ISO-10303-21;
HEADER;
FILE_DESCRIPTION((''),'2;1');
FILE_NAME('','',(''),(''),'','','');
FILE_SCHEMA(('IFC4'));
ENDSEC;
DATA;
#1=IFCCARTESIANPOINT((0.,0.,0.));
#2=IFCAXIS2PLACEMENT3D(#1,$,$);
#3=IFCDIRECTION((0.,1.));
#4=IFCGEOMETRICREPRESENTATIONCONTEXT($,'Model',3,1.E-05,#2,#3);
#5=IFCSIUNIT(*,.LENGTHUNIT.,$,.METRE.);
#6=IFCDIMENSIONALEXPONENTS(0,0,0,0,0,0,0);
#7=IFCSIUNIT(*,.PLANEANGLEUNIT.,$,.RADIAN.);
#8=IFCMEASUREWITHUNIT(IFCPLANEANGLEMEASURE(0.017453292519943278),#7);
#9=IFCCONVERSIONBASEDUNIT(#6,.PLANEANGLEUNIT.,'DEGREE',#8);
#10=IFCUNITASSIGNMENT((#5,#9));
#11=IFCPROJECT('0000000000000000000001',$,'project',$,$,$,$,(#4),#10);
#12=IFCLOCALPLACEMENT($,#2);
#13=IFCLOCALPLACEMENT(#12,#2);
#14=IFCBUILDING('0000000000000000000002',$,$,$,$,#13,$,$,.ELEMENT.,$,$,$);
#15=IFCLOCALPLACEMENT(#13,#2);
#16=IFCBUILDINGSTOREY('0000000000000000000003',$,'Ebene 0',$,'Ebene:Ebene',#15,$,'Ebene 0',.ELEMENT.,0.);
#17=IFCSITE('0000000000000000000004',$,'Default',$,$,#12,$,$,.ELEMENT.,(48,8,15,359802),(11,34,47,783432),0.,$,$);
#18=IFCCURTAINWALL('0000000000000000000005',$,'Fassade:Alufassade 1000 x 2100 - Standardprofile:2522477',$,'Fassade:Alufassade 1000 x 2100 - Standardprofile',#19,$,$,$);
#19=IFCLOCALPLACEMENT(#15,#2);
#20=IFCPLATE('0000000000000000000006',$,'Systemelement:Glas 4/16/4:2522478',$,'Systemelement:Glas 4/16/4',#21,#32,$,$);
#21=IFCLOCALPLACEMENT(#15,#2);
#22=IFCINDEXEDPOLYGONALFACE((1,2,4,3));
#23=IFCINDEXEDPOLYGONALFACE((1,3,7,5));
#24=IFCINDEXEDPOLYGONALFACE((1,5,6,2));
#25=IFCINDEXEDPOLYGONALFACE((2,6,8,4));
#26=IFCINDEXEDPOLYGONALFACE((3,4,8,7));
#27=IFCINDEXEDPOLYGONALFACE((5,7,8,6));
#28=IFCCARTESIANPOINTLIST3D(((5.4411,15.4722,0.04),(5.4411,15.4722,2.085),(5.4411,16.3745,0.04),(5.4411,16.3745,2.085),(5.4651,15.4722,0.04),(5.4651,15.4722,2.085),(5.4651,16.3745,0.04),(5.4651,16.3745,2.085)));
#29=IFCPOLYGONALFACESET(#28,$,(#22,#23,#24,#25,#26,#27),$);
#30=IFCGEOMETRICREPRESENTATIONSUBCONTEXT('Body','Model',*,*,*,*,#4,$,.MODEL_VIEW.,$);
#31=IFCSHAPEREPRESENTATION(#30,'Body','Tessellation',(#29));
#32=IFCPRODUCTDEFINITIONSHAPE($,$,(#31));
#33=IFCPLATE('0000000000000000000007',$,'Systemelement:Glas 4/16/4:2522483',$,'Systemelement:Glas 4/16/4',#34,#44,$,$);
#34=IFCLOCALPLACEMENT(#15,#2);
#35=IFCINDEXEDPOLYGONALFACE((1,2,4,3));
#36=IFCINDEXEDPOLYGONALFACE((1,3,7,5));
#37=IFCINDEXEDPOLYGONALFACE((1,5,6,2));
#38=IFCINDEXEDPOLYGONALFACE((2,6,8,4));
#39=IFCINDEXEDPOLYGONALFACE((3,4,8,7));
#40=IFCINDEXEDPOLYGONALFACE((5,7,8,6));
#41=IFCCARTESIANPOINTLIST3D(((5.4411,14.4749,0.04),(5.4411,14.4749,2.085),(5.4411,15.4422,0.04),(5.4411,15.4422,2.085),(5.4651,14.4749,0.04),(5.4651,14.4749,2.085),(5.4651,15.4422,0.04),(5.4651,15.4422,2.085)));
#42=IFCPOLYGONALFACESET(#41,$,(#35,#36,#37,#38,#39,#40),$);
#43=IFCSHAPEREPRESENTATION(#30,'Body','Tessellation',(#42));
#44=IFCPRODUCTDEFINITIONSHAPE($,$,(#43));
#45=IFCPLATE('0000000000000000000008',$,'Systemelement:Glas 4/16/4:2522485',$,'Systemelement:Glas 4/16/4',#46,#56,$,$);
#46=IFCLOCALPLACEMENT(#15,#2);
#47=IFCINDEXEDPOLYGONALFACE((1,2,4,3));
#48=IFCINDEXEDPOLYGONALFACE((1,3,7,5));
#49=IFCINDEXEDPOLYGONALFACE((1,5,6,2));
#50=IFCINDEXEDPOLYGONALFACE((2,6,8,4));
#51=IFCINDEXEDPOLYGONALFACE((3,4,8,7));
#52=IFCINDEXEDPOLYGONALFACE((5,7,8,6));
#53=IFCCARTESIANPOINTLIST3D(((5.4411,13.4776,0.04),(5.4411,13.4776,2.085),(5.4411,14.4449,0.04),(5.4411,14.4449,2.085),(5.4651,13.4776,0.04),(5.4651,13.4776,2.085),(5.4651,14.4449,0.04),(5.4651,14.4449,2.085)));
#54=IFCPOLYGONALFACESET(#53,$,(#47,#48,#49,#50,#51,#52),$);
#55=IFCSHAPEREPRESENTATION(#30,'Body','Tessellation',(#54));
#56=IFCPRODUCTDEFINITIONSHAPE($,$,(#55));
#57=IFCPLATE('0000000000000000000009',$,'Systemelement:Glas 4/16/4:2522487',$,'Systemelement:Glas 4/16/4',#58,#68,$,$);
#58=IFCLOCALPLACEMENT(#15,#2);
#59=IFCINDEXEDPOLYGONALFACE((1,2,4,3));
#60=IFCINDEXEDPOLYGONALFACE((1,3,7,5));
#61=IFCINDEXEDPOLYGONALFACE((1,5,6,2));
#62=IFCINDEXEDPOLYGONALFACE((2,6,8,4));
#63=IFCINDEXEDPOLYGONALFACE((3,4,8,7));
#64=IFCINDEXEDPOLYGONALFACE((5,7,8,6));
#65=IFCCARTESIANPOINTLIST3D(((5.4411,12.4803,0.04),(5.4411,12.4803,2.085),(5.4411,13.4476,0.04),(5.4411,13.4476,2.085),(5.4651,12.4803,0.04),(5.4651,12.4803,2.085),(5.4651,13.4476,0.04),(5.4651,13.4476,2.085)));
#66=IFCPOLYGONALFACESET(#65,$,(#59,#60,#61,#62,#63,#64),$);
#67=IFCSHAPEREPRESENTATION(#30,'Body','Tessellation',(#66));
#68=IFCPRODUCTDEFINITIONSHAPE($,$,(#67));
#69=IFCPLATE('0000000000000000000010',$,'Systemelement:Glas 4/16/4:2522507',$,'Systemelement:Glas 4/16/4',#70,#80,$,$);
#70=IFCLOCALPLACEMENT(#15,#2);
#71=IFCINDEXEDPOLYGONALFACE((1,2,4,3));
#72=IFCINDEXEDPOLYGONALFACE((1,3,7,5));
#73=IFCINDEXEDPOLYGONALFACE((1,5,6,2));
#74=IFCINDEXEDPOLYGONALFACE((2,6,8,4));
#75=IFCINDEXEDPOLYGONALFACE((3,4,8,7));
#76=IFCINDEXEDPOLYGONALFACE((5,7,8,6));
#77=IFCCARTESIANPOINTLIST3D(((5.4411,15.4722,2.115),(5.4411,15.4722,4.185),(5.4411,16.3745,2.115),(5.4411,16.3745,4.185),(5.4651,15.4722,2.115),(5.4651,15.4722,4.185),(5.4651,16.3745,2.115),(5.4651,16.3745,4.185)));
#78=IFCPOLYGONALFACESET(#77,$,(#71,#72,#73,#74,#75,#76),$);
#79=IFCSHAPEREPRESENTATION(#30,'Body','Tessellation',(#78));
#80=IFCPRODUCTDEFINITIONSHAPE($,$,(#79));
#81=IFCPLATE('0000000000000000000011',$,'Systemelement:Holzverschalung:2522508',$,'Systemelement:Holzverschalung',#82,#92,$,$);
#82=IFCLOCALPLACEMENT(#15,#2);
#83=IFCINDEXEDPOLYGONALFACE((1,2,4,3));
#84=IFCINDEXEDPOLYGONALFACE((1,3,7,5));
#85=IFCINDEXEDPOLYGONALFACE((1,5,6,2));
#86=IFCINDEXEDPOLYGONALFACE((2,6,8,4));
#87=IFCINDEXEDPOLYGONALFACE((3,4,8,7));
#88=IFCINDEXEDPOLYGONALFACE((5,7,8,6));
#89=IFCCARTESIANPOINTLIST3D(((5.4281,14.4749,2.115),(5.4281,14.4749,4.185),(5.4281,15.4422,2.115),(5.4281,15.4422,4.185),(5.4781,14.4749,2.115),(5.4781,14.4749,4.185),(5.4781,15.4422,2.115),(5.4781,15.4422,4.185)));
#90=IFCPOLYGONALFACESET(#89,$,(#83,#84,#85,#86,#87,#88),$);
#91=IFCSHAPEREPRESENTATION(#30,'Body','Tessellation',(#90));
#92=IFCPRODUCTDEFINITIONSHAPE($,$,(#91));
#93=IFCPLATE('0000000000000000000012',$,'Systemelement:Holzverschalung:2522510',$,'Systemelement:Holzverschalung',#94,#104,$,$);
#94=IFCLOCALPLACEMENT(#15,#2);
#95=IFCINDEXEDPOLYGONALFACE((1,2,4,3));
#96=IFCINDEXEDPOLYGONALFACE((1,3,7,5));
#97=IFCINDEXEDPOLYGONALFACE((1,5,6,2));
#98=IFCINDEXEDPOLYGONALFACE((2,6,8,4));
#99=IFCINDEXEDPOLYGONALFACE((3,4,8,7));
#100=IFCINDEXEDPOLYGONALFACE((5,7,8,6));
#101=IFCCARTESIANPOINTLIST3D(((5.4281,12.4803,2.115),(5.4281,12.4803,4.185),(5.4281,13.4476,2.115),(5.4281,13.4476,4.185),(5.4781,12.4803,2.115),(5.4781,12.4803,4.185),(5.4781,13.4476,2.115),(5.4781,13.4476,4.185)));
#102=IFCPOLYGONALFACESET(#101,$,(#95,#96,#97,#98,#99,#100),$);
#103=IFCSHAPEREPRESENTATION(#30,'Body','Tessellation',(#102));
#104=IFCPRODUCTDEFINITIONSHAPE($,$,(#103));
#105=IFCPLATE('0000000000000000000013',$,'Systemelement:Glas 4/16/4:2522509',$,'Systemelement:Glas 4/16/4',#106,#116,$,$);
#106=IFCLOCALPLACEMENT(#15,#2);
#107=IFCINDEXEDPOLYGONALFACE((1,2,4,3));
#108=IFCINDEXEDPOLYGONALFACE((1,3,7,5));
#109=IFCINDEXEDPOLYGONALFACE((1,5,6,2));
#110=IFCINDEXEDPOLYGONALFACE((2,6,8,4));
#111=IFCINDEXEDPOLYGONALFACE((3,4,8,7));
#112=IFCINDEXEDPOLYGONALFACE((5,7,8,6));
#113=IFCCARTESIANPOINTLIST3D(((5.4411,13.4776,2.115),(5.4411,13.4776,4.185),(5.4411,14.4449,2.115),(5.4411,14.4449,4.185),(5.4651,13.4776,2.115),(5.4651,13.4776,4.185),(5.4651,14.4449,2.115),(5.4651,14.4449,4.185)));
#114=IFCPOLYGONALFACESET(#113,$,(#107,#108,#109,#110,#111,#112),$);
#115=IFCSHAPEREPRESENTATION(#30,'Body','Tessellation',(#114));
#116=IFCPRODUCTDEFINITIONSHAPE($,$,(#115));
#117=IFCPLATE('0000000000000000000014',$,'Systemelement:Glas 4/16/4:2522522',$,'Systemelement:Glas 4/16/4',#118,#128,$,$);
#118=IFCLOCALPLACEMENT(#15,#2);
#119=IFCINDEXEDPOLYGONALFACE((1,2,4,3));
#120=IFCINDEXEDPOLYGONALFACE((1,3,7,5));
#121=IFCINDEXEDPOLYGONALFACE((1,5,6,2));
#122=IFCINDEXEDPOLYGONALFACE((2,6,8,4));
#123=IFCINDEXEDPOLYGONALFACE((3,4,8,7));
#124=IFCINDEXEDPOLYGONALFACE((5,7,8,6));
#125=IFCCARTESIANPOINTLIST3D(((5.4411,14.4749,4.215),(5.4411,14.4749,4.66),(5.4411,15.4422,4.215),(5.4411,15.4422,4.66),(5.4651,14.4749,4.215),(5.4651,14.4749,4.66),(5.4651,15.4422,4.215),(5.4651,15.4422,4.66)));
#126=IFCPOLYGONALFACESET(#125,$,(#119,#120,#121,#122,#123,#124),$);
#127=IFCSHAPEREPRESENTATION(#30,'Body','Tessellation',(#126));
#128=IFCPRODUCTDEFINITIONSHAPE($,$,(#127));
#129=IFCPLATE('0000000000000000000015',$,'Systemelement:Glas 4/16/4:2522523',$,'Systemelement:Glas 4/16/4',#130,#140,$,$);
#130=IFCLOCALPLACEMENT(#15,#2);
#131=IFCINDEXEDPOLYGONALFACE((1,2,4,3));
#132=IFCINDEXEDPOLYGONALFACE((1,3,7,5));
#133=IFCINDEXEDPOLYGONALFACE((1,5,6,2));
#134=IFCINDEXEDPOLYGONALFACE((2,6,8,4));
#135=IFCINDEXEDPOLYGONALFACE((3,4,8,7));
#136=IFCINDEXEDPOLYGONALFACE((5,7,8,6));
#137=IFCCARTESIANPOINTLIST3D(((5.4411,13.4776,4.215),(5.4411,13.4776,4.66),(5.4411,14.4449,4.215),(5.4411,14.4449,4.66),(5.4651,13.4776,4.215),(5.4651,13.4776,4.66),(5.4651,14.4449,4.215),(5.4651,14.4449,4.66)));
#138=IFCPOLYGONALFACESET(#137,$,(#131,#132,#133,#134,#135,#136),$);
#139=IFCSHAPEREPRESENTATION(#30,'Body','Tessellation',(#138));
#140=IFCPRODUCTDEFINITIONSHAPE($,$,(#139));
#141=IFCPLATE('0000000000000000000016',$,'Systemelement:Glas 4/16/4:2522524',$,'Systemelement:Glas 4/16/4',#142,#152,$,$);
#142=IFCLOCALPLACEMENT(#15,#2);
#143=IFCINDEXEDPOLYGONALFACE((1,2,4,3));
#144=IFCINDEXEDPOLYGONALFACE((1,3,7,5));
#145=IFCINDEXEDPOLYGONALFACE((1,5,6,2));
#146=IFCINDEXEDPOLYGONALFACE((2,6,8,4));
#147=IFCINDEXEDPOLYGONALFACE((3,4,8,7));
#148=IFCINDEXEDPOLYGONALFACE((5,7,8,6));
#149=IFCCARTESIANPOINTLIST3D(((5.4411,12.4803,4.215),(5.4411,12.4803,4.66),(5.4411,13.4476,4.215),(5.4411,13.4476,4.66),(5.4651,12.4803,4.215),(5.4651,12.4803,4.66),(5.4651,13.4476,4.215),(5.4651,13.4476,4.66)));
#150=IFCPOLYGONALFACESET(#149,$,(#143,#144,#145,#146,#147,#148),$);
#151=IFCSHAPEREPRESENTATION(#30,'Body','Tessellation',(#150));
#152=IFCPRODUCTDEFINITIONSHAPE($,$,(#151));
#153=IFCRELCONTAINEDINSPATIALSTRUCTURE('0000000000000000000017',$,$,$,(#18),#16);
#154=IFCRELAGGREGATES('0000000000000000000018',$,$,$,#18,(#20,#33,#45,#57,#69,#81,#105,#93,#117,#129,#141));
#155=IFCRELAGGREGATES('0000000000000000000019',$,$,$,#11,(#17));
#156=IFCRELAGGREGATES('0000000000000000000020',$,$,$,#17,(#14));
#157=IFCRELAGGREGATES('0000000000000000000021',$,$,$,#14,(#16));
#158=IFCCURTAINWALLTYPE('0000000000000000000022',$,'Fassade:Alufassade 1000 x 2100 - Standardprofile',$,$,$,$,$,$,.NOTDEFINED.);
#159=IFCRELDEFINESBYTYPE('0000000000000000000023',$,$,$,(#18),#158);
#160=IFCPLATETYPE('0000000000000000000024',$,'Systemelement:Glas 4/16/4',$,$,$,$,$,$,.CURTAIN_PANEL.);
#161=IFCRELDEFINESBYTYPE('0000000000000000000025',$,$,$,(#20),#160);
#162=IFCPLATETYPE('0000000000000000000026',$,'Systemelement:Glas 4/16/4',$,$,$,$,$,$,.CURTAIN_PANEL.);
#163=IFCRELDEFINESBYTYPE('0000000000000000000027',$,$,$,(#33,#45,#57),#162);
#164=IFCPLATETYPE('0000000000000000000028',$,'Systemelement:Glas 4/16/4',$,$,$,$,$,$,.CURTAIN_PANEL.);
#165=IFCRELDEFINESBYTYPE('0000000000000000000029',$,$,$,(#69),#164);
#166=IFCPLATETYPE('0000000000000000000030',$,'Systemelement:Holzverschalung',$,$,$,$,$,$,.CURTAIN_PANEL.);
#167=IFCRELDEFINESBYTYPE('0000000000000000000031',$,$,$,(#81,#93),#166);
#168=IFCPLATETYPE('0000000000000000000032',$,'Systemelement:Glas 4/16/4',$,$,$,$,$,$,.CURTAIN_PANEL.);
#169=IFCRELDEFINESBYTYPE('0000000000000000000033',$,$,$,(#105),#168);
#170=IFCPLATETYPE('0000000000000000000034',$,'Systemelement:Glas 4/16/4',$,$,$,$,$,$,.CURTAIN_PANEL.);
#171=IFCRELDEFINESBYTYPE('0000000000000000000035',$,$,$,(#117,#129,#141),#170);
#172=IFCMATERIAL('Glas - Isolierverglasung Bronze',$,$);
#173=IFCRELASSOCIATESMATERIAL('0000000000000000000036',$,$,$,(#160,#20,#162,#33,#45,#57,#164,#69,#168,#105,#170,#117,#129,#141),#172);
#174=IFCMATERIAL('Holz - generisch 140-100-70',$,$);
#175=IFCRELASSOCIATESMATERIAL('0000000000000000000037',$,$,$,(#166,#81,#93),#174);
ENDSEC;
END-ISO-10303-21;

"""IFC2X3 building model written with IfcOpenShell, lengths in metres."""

from ifc_helpers import new_model, entity, si_unit, converted_unit, direction, frame, origin, origin_2d_with_axis, place, context, subcontext, project, spatial, rectangle, extrude, source, transform, mapped, material, type_object, type_shapes, element, aggregate, save


model = new_model("IFC2X3")

# Units and contexts
model_context = context("Model", 3, precision=1e-05, world=origin(), true_north=direction((0.0, 1.0)))
body_context = subcontext(model_context, "Body", "Model", "MODEL_VIEW")
ifc_project = project(units=[si_unit("LENGTHUNIT", "METRE"), converted_unit("PLANEANGLEUNIT", "DEGREE", entity("IfcPlaneAngleMeasure", 0.017453292519943278), si_unit("PLANEANGLEUNIT", "RADIAN"), dimensions=[0, 0, 0, 0, 0, 0, 0])], contexts=[model_context])

# Site, building, storey
site_placement = place(None, origin())
site = spatial("IfcSite", under=ifc_project, at=site_placement, Name="Default", CompositionType="ELEMENT", RefLatitude=(48, 8, 15, 359802), RefLongitude=(11, 34, 47, 783432), RefElevation=0.0)
building_placement = place(site_placement, origin())
building = spatial("IfcBuilding", under=site, at=building_placement, CompositionType="ELEMENT")
storey_placement = place(building_placement, origin())
storey = spatial("IfcBuildingStorey", under=building, at=storey_placement, Name="Ebene 0", ObjectType="Ebene:Ebene", LongName="Ebene 0", CompositionType="ELEMENT", Elevation=0.0)

# Curtain wall, plates
curtain_wall_type = type_object("IfcCurtainWallType", Name="Fassade:Alufassade 1000 x 2100 - Standardprofile", PredefinedType="NOTDEFINED")
curtain_wall_placement = place(storey_placement, origin())
curtain_wall = element("IfcCurtainWall", 1, at=curtain_wall_placement, inside=storey, type_object=curtain_wall_type, Name="Fassade:Alufassade 1000 x 2100 - Standardprofile:2522477", ObjectType="Fassade:Alufassade 1000 x 2100 - Standardprofile")
ifc_material_1 = material(Name="Glas - Isolierverglasung Bronze")
plate_type_1 = type_object("IfcPlateType", Name="Systemelement:Glas 4/16/4", PredefinedType="CURTAIN_PANEL", material=ifc_material_1)
shared_shape_1 = source(origin(), body_context, "Body", "SweptSolid", [
    extrude(rectangle(XDim=0.024, YDim=0.9023, at=origin_2d_with_axis()), frame((0.0, 0.0, 0.0), z_axis=(0.0, 0.0, 1.0), x_axis=(0.0, 1.0, 0.0)), (0.0, 0.0, 1.0), 2.045),
])
type_shapes(plate_type_1, [shared_shape_1])
plate_1_placement = place(curtain_wall_placement, frame((5.4531, 15.9233, 0.04), z_axis=(0.0, 0.0, 1.0), x_axis=(0.0, -1.0, 0.0)))
plate_1 = element("IfcPlate", 2, at=plate_1_placement, type_object=plate_type_1, material=ifc_material_1, Name="Systemelement:Glas 4/16/4:2522478", ObjectType="Systemelement:Glas 4/16/4", context=body_context, shape_type="MappedRepresentation", body=[
    mapped(shared_shape_1, transform((0.0, 0.0, 0.0), scale=1.0)),
])
plate_type_2 = type_object("IfcPlateType", Name="Systemelement:Glas 4/16/4", PredefinedType="CURTAIN_PANEL", material=ifc_material_1)
shared_shape_2 = source(origin(), body_context, "Body", "SweptSolid", [
    extrude(rectangle(XDim=0.024, YDim=0.9673, at=origin_2d_with_axis()), frame((0.0, 0.0, 0.0), z_axis=(0.0, 0.0, 1.0), x_axis=(0.0, 1.0, 0.0)), (0.0, 0.0, 1.0), 2.045),
])
type_shapes(plate_type_2, [shared_shape_2])
plate_2_placement = place(curtain_wall_placement, frame((5.4531, 14.9585, 0.04), z_axis=(0.0, 0.0, 1.0), x_axis=(0.0, -1.0, 0.0)))
plate_2 = element("IfcPlate", 3, at=plate_2_placement, type_object=plate_type_2, material=ifc_material_1, Name="Systemelement:Glas 4/16/4:2522483", ObjectType="Systemelement:Glas 4/16/4", context=body_context, shape_type="MappedRepresentation", body=[
    mapped(shared_shape_2, transform((0.0, 0.0, 0.0), scale=1.0)),
])
plate_3_placement = place(curtain_wall_placement, frame((5.4531, 13.9612, 0.04), z_axis=(0.0, 0.0, 1.0), x_axis=(0.0, -1.0, 0.0)))
plate_3 = element("IfcPlate", 4, at=plate_3_placement, type_object=plate_type_2, material=ifc_material_1, Name="Systemelement:Glas 4/16/4:2522485", ObjectType="Systemelement:Glas 4/16/4", context=body_context, shape_type="MappedRepresentation", body=[
    mapped(shared_shape_2, transform((0.0, 0.0, 0.0), scale=1.0)),
])
plate_4_placement = place(curtain_wall_placement, frame((5.4531, 12.9639, 0.04), z_axis=(0.0, 0.0, 1.0), x_axis=(0.0, -1.0, 0.0)))
plate_4 = element("IfcPlate", 5, at=plate_4_placement, type_object=plate_type_2, material=ifc_material_1, Name="Systemelement:Glas 4/16/4:2522487", ObjectType="Systemelement:Glas 4/16/4", context=body_context, shape_type="MappedRepresentation", body=[
    mapped(shared_shape_2, transform((0.0, 0.0, 0.0), scale=1.0)),
])
plate_type_3 = type_object("IfcPlateType", Name="Systemelement:Glas 4/16/4", PredefinedType="CURTAIN_PANEL", material=ifc_material_1)
shared_shape_3 = source(origin(), body_context, "Body", "SweptSolid", [
    extrude(rectangle(XDim=0.024, YDim=0.9023, at=origin_2d_with_axis()), frame((0.0, 0.0, 0.0), z_axis=(0.0, 0.0, 1.0), x_axis=(0.0, 1.0, 0.0)), (0.0, 0.0, 1.0), 2.07),
])
type_shapes(plate_type_3, [shared_shape_3])
plate_5_placement = place(curtain_wall_placement, frame((5.4531, 15.9233, 2.115), z_axis=(0.0, 0.0, 1.0), x_axis=(0.0, -1.0, 0.0)))
plate_5 = element("IfcPlate", 6, at=plate_5_placement, type_object=plate_type_3, material=ifc_material_1, Name="Systemelement:Glas 4/16/4:2522507", ObjectType="Systemelement:Glas 4/16/4", context=body_context, shape_type="MappedRepresentation", body=[
    mapped(shared_shape_3, transform((0.0, 0.0, 0.0), scale=1.0)),
])
ifc_material_2 = material(Name="Holz - generisch 140-100-70")
plate_type_4 = type_object("IfcPlateType", Name="Systemelement:Holzverschalung", PredefinedType="CURTAIN_PANEL", material=ifc_material_2)
shared_shape_4 = source(origin(), body_context, "Body", "SweptSolid", [
    extrude(rectangle(XDim=0.05, YDim=0.9673, at=origin_2d_with_axis()), frame((0.0, 0.0, 0.0), z_axis=(0.0, 0.0, 1.0), x_axis=(0.0, 1.0, 0.0)), (0.0, 0.0, 1.0), 2.07),
])
type_shapes(plate_type_4, [shared_shape_4])
plate_6_placement = place(curtain_wall_placement, frame((5.4531, 14.9585, 2.115), z_axis=(0.0, 0.0, 1.0), x_axis=(0.0, -1.0, 0.0)))
plate_6 = element("IfcPlate", 7, at=plate_6_placement, type_object=plate_type_4, material=ifc_material_2, Name="Systemelement:Holzverschalung:2522508", ObjectType="Systemelement:Holzverschalung", context=body_context, shape_type="MappedRepresentation", body=[
    mapped(shared_shape_4, transform((0.0, 0.0, 0.0), scale=1.0)),
])
plate_7_placement = place(curtain_wall_placement, frame((5.4531, 12.9639, 2.115), z_axis=(0.0, 0.0, 1.0), x_axis=(0.0, -1.0, 0.0)))
plate_7 = element("IfcPlate", 8, at=plate_7_placement, type_object=plate_type_4, material=ifc_material_2, Name="Systemelement:Holzverschalung:2522510", ObjectType="Systemelement:Holzverschalung", context=body_context, shape_type="MappedRepresentation", body=[
    mapped(shared_shape_4, transform((0.0, 0.0, 0.0), scale=1.0)),
])
plate_type_5 = type_object("IfcPlateType", Name="Systemelement:Glas 4/16/4", PredefinedType="CURTAIN_PANEL", material=ifc_material_1)
shared_shape_5 = source(origin(), body_context, "Body", "SweptSolid", [
    extrude(rectangle(XDim=0.024, YDim=0.9673, at=origin_2d_with_axis()), frame((0.0, 0.0, 0.0), z_axis=(0.0, 0.0, 1.0), x_axis=(0.0, 1.0, 0.0)), (0.0, 0.0, 1.0), 2.07),
])
type_shapes(plate_type_5, [shared_shape_5])
plate_8_placement = place(curtain_wall_placement, frame((5.4531, 13.9612, 2.115), z_axis=(0.0, 0.0, 1.0), x_axis=(0.0, -1.0, 0.0)))
plate_8 = element("IfcPlate", 9, at=plate_8_placement, type_object=plate_type_5, material=ifc_material_1, Name="Systemelement:Glas 4/16/4:2522509", ObjectType="Systemelement:Glas 4/16/4", context=body_context, shape_type="MappedRepresentation", body=[
    mapped(shared_shape_5, transform((0.0, 0.0, 0.0), scale=1.0)),
])
plate_type_6 = type_object("IfcPlateType", Name="Systemelement:Glas 4/16/4", PredefinedType="CURTAIN_PANEL", material=ifc_material_1)
shared_shape_6 = source(origin(), body_context, "Body", "SweptSolid", [
    extrude(rectangle(XDim=0.024, YDim=0.9673, at=origin_2d_with_axis()), frame((0.0, 0.0, 0.0), z_axis=(0.0, 0.0, 1.0), x_axis=(0.0, 1.0, 0.0)), (0.0, 0.0, 1.0), 0.445),
])
type_shapes(plate_type_6, [shared_shape_6])
plate_9_placement = place(curtain_wall_placement, frame((5.4531, 14.9585, 4.215), z_axis=(0.0, 0.0, 1.0), x_axis=(0.0, -1.0, 0.0)))
plate_9 = element("IfcPlate", 10, at=plate_9_placement, type_object=plate_type_6, material=ifc_material_1, Name="Systemelement:Glas 4/16/4:2522522", ObjectType="Systemelement:Glas 4/16/4", context=body_context, shape_type="MappedRepresentation", body=[
    mapped(shared_shape_6, transform((0.0, 0.0, 0.0), scale=1.0)),
])
plate_10_placement = place(curtain_wall_placement, frame((5.4531, 13.9612, 4.215), z_axis=(0.0, 0.0, 1.0), x_axis=(0.0, -1.0, 0.0)))
plate_10 = element("IfcPlate", 11, at=plate_10_placement, type_object=plate_type_6, material=ifc_material_1, Name="Systemelement:Glas 4/16/4:2522523", ObjectType="Systemelement:Glas 4/16/4", context=body_context, shape_type="MappedRepresentation", body=[
    mapped(shared_shape_6, transform((0.0, 0.0, 0.0), scale=1.0)),
])
plate_11_placement = place(curtain_wall_placement, frame((5.4531, 12.9639, 4.215), z_axis=(0.0, 0.0, 1.0), x_axis=(0.0, -1.0, 0.0)))
plate_11 = element("IfcPlate", 12, at=plate_11_placement, type_object=plate_type_6, material=ifc_material_1, Name="Systemelement:Glas 4/16/4:2522524", ObjectType="Systemelement:Glas 4/16/4", context=body_context, shape_type="MappedRepresentation", body=[
    mapped(shared_shape_6, transform((0.0, 0.0, 0.0), scale=1.0)),
])
aggregate(curtain_wall, [plate_1, plate_2, plate_3, plate_4, plate_5, plate_6, plate_8, plate_7, plate_9, plate_10, plate_11])

save(model, "model.ifc")
